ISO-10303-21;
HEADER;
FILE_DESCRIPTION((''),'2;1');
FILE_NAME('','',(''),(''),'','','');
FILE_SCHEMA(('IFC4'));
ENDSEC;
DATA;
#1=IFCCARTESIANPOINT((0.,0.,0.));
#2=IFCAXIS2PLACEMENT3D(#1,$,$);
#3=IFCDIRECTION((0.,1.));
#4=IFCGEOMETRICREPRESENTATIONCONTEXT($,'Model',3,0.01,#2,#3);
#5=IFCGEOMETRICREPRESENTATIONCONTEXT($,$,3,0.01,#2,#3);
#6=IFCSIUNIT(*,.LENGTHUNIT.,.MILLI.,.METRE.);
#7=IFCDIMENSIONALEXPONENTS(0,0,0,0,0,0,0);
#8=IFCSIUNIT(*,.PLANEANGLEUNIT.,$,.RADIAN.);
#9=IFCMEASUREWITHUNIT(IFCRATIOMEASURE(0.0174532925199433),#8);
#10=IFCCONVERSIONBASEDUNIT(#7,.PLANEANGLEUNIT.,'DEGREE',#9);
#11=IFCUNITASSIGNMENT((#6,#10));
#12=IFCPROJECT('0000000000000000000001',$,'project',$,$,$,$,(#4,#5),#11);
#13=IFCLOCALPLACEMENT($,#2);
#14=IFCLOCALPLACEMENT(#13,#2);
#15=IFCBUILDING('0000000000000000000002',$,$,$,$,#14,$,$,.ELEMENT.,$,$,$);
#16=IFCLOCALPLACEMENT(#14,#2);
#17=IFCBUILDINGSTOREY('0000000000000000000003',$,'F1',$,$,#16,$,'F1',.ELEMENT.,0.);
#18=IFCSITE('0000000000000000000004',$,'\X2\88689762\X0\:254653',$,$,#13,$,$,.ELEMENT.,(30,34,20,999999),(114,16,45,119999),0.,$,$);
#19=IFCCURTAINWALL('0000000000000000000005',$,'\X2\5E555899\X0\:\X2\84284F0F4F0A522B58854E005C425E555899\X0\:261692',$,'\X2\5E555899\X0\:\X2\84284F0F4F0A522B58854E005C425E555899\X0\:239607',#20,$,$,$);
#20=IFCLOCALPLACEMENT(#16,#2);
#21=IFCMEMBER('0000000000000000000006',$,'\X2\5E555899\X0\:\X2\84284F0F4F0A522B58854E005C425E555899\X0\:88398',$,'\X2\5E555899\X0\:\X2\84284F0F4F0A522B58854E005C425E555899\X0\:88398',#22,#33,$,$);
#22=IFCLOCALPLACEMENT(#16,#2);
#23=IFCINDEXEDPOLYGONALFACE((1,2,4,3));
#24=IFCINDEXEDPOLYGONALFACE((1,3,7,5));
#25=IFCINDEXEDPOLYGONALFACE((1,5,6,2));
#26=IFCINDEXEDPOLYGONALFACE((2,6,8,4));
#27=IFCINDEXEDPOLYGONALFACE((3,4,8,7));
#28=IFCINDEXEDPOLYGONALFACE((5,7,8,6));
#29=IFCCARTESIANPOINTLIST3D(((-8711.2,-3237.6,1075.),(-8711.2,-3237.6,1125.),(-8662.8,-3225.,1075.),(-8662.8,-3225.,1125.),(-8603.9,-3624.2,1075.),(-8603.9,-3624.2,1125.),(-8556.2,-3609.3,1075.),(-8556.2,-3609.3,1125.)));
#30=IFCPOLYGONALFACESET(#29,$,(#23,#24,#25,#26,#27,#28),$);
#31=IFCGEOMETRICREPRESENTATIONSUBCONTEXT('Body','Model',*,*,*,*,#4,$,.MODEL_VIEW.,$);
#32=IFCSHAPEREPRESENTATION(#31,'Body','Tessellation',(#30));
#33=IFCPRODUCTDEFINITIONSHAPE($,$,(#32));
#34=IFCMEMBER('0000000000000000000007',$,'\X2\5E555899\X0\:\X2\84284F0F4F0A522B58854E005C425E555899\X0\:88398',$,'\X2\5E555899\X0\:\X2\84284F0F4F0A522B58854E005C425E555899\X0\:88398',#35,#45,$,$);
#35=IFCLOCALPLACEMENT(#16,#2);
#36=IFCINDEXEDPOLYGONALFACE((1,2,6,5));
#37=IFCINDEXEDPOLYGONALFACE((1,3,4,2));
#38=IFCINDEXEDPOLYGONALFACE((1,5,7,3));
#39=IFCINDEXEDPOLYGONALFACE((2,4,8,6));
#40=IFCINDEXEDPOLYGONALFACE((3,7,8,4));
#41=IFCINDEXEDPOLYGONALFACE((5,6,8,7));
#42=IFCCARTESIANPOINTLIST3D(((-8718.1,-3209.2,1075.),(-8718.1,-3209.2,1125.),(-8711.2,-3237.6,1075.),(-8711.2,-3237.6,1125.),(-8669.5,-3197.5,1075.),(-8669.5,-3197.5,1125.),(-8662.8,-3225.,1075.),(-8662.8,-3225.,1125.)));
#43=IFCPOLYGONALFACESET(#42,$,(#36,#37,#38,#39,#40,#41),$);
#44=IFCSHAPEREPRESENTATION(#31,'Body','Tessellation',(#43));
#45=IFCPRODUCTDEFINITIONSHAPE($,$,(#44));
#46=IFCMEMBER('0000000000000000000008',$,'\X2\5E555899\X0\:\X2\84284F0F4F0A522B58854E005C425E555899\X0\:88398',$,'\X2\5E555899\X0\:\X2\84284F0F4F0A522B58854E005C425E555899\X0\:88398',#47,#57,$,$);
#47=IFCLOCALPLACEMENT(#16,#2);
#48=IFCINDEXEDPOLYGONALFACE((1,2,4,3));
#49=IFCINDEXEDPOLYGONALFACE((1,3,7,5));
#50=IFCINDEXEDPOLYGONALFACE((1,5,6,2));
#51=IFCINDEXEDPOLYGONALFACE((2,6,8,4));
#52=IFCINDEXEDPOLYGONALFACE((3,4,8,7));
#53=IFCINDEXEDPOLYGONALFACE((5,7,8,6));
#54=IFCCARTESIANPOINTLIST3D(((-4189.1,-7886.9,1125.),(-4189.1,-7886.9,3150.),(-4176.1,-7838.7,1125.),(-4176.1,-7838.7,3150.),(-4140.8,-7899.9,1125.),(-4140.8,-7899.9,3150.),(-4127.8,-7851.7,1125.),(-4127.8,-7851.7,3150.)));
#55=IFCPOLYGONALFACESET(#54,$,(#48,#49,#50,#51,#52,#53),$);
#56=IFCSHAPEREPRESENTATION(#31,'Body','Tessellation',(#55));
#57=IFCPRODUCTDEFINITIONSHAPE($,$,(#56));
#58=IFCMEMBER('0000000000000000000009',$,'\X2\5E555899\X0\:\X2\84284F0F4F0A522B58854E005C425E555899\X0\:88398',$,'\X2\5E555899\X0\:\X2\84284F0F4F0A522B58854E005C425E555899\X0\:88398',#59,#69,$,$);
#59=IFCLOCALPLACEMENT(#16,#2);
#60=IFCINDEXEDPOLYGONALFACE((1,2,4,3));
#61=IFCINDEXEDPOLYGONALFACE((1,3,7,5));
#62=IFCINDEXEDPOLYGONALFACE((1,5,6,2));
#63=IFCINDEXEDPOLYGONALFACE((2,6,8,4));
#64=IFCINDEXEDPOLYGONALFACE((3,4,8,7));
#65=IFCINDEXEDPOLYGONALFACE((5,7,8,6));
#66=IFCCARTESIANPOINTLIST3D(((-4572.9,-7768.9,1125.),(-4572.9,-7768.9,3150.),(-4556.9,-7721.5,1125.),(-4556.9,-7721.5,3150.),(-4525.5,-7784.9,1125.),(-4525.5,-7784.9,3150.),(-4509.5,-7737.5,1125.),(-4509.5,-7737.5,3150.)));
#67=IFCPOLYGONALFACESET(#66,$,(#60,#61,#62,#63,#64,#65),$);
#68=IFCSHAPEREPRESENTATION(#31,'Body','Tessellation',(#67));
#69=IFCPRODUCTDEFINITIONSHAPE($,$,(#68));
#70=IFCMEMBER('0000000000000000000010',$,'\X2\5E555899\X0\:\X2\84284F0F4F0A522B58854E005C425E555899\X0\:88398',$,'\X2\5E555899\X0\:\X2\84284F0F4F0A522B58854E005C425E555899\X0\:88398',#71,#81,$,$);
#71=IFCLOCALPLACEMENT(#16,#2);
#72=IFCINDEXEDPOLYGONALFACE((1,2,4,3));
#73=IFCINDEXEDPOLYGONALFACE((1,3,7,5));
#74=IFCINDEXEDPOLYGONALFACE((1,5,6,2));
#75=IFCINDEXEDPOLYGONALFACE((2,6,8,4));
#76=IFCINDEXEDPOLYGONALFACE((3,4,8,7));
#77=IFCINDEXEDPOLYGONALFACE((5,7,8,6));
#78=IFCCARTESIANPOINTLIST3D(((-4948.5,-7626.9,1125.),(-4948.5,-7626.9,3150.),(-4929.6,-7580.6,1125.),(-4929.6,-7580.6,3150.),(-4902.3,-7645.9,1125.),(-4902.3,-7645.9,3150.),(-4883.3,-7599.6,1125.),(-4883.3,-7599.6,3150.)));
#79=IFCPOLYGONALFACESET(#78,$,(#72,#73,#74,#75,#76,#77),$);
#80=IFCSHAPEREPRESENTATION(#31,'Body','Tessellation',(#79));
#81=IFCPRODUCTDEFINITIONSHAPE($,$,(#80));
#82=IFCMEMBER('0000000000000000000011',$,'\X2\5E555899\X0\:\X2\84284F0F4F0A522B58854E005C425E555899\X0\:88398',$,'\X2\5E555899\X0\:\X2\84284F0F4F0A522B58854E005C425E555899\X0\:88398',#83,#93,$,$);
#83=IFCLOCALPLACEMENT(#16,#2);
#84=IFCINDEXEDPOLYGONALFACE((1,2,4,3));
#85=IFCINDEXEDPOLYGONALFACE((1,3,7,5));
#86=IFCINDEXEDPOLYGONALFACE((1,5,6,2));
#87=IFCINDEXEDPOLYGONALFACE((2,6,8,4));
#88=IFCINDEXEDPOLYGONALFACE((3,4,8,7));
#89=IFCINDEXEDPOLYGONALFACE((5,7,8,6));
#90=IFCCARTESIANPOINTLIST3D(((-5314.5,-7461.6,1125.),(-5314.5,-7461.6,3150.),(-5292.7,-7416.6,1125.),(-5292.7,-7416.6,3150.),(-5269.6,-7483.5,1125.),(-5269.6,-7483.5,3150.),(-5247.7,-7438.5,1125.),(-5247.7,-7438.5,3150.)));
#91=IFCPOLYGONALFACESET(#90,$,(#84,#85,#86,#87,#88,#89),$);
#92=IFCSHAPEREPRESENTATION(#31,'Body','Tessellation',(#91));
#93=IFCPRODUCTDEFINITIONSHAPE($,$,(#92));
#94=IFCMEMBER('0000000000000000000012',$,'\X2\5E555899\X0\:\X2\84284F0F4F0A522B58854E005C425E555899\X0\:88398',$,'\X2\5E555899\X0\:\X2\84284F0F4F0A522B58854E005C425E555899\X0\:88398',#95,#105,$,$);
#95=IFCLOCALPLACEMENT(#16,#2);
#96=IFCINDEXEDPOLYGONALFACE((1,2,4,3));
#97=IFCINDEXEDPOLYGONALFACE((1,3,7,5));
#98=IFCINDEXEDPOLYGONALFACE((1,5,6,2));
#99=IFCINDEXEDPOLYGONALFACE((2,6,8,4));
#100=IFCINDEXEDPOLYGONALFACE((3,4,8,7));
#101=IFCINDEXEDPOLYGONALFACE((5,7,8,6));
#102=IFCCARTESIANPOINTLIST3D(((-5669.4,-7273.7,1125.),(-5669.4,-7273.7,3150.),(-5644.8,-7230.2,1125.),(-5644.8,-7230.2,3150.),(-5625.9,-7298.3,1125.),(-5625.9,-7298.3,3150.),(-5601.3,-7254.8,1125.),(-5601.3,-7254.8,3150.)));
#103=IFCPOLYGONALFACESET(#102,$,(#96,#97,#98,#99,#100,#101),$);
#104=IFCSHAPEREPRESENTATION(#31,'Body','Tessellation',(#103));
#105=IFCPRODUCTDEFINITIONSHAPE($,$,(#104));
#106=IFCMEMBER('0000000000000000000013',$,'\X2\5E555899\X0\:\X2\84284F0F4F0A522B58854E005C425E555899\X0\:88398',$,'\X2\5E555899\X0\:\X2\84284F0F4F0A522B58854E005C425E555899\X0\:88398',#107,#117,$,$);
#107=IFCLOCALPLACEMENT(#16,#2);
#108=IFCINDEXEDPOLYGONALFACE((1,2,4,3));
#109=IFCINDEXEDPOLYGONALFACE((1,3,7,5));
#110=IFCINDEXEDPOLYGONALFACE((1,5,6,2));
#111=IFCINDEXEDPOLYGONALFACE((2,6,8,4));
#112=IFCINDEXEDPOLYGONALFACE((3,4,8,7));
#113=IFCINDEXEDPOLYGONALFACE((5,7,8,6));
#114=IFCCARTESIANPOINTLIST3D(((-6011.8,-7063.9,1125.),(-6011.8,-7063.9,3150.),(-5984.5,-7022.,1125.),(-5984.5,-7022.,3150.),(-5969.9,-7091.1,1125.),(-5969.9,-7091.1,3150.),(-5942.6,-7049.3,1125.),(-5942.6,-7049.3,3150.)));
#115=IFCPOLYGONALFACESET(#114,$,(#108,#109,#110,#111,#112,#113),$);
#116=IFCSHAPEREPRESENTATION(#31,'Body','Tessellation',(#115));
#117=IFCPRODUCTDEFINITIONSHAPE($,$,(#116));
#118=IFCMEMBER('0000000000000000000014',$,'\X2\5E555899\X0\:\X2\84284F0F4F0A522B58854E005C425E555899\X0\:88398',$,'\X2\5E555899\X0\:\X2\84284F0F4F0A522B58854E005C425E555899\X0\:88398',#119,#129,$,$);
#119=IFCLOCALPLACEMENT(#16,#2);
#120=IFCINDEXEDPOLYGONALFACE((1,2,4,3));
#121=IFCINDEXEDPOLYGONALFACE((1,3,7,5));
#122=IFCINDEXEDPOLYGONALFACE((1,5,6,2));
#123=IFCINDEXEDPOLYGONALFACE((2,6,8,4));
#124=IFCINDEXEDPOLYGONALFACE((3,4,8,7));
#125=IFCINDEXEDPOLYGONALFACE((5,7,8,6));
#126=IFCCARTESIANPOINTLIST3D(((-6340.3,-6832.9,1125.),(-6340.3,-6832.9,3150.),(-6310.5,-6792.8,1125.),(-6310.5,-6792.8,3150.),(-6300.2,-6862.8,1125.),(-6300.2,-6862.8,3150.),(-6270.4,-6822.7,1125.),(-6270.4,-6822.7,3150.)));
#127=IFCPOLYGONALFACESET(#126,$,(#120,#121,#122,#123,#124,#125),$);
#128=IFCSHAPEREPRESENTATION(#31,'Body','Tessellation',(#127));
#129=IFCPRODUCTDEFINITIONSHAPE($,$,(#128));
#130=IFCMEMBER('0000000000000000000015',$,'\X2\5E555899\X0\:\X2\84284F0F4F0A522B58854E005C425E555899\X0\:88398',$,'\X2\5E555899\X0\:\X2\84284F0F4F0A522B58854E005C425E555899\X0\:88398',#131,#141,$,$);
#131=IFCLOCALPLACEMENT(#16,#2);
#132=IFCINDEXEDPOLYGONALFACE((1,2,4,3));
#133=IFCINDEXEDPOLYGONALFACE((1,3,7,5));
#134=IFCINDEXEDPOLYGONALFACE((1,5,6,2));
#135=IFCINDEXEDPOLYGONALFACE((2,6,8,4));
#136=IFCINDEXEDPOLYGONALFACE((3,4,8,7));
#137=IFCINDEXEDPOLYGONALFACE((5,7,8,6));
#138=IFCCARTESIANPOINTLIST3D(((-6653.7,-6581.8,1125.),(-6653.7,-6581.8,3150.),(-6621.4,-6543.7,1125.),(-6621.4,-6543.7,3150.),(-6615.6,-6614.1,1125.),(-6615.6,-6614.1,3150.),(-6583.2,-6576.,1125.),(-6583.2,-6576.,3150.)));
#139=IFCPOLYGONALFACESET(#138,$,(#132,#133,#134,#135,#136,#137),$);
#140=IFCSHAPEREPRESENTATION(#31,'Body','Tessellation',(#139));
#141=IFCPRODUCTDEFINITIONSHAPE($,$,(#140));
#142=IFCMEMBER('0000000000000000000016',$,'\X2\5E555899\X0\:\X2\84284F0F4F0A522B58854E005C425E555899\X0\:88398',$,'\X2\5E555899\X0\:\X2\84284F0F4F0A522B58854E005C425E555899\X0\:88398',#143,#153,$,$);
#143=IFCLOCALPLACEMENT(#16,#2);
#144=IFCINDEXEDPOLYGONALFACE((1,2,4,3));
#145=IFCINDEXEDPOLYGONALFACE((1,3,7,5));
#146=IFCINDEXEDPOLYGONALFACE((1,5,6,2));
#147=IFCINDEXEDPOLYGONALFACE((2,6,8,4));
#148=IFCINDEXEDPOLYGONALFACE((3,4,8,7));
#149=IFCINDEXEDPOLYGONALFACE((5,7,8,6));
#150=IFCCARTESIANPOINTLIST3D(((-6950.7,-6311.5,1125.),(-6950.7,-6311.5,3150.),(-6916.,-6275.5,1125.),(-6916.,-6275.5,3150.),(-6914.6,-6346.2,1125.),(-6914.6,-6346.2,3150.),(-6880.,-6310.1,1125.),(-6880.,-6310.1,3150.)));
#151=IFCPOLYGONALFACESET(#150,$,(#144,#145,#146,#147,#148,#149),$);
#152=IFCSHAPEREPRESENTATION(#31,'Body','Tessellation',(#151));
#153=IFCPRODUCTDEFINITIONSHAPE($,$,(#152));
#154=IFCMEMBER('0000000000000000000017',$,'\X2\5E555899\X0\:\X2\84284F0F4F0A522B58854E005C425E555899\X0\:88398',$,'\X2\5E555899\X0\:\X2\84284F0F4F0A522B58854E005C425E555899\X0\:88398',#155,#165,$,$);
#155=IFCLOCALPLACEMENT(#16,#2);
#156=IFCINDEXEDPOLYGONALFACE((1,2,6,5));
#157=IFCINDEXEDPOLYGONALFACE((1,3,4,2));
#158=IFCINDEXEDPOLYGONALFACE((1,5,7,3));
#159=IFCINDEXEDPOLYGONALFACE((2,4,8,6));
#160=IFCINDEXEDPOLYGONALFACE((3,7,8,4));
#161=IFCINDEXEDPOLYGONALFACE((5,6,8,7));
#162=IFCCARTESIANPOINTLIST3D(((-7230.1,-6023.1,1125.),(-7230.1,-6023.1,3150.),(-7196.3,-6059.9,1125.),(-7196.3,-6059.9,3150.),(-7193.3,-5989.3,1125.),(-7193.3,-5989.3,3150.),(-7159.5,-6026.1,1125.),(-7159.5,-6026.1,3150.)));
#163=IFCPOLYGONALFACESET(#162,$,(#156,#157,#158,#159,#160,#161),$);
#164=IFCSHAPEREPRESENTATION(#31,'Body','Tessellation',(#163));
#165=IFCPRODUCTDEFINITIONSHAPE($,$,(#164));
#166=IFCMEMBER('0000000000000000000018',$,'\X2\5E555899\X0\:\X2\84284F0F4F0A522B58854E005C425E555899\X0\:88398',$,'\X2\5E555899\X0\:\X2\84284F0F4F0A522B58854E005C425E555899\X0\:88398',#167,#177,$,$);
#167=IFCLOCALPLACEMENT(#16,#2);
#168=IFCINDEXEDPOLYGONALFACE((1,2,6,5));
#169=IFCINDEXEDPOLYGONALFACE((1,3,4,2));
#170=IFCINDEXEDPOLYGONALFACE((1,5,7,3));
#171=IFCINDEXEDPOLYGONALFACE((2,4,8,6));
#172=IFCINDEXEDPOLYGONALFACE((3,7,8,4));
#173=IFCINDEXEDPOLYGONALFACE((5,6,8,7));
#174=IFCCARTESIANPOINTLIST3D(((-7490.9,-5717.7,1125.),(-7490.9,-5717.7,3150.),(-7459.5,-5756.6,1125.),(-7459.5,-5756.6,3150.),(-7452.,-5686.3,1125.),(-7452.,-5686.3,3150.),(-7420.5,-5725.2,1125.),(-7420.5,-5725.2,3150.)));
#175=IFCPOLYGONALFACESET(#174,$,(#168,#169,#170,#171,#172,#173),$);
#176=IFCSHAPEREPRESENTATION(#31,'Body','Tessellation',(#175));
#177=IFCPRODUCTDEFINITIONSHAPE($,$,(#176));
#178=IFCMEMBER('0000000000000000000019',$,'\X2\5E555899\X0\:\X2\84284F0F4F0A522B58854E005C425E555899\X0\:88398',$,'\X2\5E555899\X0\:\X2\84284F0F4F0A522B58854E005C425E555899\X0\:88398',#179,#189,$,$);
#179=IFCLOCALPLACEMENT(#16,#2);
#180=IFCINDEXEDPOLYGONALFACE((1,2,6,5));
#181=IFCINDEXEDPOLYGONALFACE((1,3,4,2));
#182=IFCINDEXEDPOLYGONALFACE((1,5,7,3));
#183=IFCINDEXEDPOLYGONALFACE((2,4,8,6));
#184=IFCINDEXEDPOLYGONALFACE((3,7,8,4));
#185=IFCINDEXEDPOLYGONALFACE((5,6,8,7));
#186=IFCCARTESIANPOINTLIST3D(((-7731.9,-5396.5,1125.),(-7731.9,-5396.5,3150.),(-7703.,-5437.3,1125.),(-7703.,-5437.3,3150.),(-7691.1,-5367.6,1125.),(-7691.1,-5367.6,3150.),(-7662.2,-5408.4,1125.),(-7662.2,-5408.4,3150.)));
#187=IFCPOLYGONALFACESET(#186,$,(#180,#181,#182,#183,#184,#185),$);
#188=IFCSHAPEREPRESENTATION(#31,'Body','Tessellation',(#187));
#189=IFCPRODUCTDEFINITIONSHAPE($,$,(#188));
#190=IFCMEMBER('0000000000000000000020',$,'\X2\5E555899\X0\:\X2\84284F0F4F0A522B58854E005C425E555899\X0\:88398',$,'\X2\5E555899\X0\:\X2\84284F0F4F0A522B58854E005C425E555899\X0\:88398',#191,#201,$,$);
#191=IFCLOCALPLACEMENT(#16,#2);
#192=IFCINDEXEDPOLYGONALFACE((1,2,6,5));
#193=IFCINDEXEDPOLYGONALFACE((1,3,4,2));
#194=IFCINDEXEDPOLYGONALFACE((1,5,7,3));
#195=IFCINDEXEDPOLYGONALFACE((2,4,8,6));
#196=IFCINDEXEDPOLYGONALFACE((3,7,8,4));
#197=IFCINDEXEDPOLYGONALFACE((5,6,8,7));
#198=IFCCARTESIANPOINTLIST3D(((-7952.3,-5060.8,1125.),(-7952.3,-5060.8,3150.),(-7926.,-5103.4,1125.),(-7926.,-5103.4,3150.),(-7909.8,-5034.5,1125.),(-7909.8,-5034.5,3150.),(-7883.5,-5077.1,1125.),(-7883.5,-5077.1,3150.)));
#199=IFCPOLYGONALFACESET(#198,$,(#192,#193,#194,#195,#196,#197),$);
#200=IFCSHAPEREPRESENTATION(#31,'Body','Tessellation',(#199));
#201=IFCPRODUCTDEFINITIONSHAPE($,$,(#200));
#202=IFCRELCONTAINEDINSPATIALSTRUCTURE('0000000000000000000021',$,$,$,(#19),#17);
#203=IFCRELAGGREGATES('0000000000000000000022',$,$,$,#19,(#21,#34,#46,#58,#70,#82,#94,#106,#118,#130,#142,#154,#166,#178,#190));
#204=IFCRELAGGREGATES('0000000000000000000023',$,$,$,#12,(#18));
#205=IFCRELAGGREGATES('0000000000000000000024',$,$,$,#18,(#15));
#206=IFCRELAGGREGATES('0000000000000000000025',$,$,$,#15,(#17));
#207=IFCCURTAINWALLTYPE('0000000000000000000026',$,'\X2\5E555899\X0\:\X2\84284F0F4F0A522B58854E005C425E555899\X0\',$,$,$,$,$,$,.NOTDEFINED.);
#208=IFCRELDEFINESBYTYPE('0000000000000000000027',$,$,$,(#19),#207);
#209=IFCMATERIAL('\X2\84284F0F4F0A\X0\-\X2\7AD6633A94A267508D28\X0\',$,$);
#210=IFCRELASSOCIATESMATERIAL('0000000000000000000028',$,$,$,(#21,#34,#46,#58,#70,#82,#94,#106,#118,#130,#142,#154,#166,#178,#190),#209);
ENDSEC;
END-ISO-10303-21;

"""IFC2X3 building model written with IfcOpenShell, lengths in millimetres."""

from ifc_helpers import new_model, entity, si_unit, converted_unit, direction, frame, frame_2d, origin, origin_2d_with_axis, place, context, subcontext, project, spatial, rectangle, extrude, clip, halfspace, material, type_object, element, aggregate, save


model = new_model("IFC2X3")

# Units and contexts
model_context = context("Model", 3, precision=0.01, world=origin(), true_north=direction((0.0, 1.0)))
context_of_model = context(None, 3, precision=0.01, world=origin(), true_north=direction((0.0, 1.0)))
body_context = subcontext(model_context, "Body", "Model", "MODEL_VIEW")
ifc_project = project(units=[si_unit("LENGTHUNIT", "METRE", prefix="MILLI"), converted_unit("PLANEANGLEUNIT", "DEGREE", entity("IfcRatioMeasure", 0.0174532925199433), si_unit("PLANEANGLEUNIT", "RADIAN"), dimensions=[0, 0, 0, 0, 0, 0, 0])], contexts=[model_context, context_of_model])

# Site, building, storey
site_placement = place(None, origin())
site = spatial("IfcSite", under=ifc_project, at=site_placement, Name="表面:254653", CompositionType="ELEMENT", RefLatitude=(30, 34, 20, 999999), RefLongitude=(114, 16, 45, 119999), RefElevation=0.0)
building_placement = place(site_placement, origin())
building = spatial("IfcBuilding", under=site, at=building_placement, CompositionType="ELEMENT")
storey_placement = place(building_placement, origin())
storey = spatial("IfcBuildingStorey", under=building, at=storey_placement, Name="F1", LongName="F1", CompositionType="ELEMENT", Elevation=0.0)

# Curtain wall, members
curtain_wall_type_1 = type_object("IfcCurtainWallType", Name="幕墙:萨伏伊别墅一层幕墙", PredefinedType="NOTDEFINED")
curtain_wall_1_placement = place(storey_placement, origin())
curtain_wall_1 = element("IfcCurtainWall", 1, at=curtain_wall_1_placement, inside=storey, type_object=curtain_wall_type_1, Name="幕墙:萨伏伊别墅一层幕墙:261692", ObjectType="幕墙:萨伏伊别墅一层幕墙:239607")
ifc_material_1 = material(Name="萨伏伊-竖挺钢材质")
member_1_placement = place(curtain_wall_1_placement, origin())
member_1 = element("IfcMember", 2, at=member_1_placement, material=ifc_material_1, Name="幕墙:萨伏伊别墅一层幕墙:88398", ObjectType="幕墙:萨伏伊别墅一层幕墙:88398", context=body_context, shape_type="Clipping", body=[
    clip(clip(extrude(rectangle(XDim=50.0, YDim=50.0, at=frame_2d((0.0, 0.0), x_axis=(1.0, 0.0))), frame((-8687.1, -3230.9, 1100.0), z_axis=(0.267379, -0.963592, 0.0), x_axis=(0.0, 0.0, -1.0)), (0.0, 0.0, 1.0), 401.2), halfspace(frame((-8687.0, -3231.3, 795.2), z_axis=(-0.251115, 0.967957, 0.0), x_axis=(0.967957, 0.251115, 0.0)), False)), halfspace(frame((-8580.1, -3616.7, 795.2), z_axis=(0.297522, -0.954715, 0.0), x_axis=(0.954715, 0.297522, 0.0)), False)),
])
member_2_placement = place(curtain_wall_1_placement, origin())
member_2 = element("IfcMember", 3, at=member_2_placement, material=ifc_material_1, Name="幕墙:萨伏伊别墅一层幕墙:88398", ObjectType="幕墙:萨伏伊别墅一层幕墙:88398", context=body_context, shape_type="Clipping", body=[
    clip(extrude(rectangle(XDim=50.0, YDim=50.0, at=frame_2d((0.0, 0.0), x_axis=(1.0, 0.0))), frame((-8693.8, -3203.4, 1100.0), z_axis=(0.234779, -0.972049, 0.0), x_axis=(0.0, 0.0, -1.0)), (0.0, 0.0, 1.0), 29.1), halfspace(frame((-8687.0, -3231.3, 795.2), z_axis=(0.251115, -0.967957, 0.0), x_axis=(0.967957, 0.251115, 0.0)), False)),
])
member_3_placement = place(curtain_wall_1_placement, origin())
member_3 = element("IfcMember", 4, at=member_3_placement, material=ifc_material_1, Name="幕墙:萨伏伊别墅一层幕墙:88398", ObjectType="幕墙:萨伏伊别墅一层幕墙:88398", context=body_context, shape_type="SweptSolid", body=[
    extrude(rectangle(XDim=50.0, YDim=50.0, at=frame_2d((0.0, 0.0), x_axis=(1.0, 0.0))), frame((-4158.4, -7869.3, 1125.0), z_axis=(0.0, 0.0, 1.0), x_axis=(0.2601, 0.965582, 0.0)), (0.0, 0.0, 1.0), 2025.0),
])
member_4_placement = place(curtain_wall_1_placement, origin())
member_4 = element("IfcMember", 5, at=member_4_placement, material=ifc_material_1, Name="幕墙:萨伏伊别墅一层幕墙:88398", ObjectType="幕墙:萨伏伊别墅一层幕墙:88398", context=body_context, shape_type="SweptSolid", body=[
    extrude(rectangle(XDim=50.0, YDim=50.0, at=origin_2d_with_axis()), frame((-4541.2, -7753.2, 1125.0), z_axis=(0.0, 0.0, 1.0), x_axis=(0.320231, 0.947339, 0.0)), (0.0, 0.0, 1.0), 2025.0),
])
member_5_placement = place(curtain_wall_1_placement, origin())
member_5 = element("IfcMember", 6, at=member_5_placement, material=ifc_material_1, Name="幕墙:萨伏伊别墅一层幕墙:88398", ObjectType="幕墙:萨伏伊别墅一层幕墙:88398", context=body_context, shape_type="SweptSolid", body=[
    extrude(rectangle(XDim=50.0, YDim=50.0, at=frame_2d((0.0, 0.0), x_axis=(1.0, 0.0))), frame((-4915.9, -7613.2, 1125.0), z_axis=(0.0, 0.0, 1.0), x_axis=(0.379099, 0.925356, 0.0)), (0.0, 0.0, 1.0), 2025.0),
])
member_6_placement = place(curtain_wall_1_placement, origin())
member_6 = element("IfcMember", 7, at=member_6_placement, material=ifc_material_1, Name="幕墙:萨伏伊别墅一层幕墙:88398", ObjectType="幕墙:萨伏伊别墅一层幕墙:88398", context=body_context, shape_type="SweptSolid", body=[
    extrude(rectangle(XDim=50.0, YDim=50.0, at=frame_2d((0.0, 0.0), x_axis=(1.0, 0.0))), frame((-5281.1, -7450.1, 1125.0), z_axis=(0.0, 0.0, 1.0), x_axis=(0.436469, 0.899719, 0.0)), (0.0, 0.0, 1.0), 2025.0),
])
member_7_placement = place(curtain_wall_1_placement, origin())
member_7 = element("IfcMember", 8, at=member_7_placement, material=ifc_material_1, Name="幕墙:萨伏伊别墅一层幕墙:88398", ObjectType="幕墙:萨伏伊别墅一层幕墙:88398", context=body_context, shape_type="SweptSolid", body=[
    extrude(rectangle(XDim=50.0, YDim=50.0, at=origin_2d_with_axis()), frame((-5635.4, -7264.2, 1125.0), z_axis=(0.0, 0.0, 1.0), x_axis=(0.492116, 0.870529, 0.0)), (0.0, 0.0, 1.0), 2025.0),
])
member_8_placement = place(curtain_wall_1_placement, origin())
member_8 = element("IfcMember", 9, at=member_8_placement, material=ifc_material_1, Name="幕墙:萨伏伊别墅一层幕墙:88398", ObjectType="幕墙:萨伏伊别墅一层幕墙:88398", context=body_context, shape_type="SweptSolid", body=[
    extrude(rectangle(XDim=50.0, YDim=50.0, at=frame_2d((0.0, 0.0), x_axis=(1.0, 0.0))), frame((-5977.2, -7056.6, 1125.0), z_axis=(0.0, 0.0, 1.0), x_axis=(0.54582, 0.837902, 0.0)), (0.0, 0.0, 1.0), 2025.0),
])
member_9_placement = place(curtain_wall_1_placement, origin())
member_9 = element("IfcMember", 10, at=member_9_placement, material=ifc_material_1, Name="幕墙:萨伏伊别墅一层幕墙:88398", ObjectType="幕墙:萨伏伊别墅一层幕墙:88398", context=body_context, shape_type="SweptSolid", body=[
    extrude(rectangle(XDim=50.0, YDim=50.0, at=origin_2d_with_axis()), frame((-6305.3, -6827.8, 1125.0), z_axis=(0.0, 0.0, 1.0), x_axis=(0.597369, 0.801967, 0.0)), (0.0, 0.0, 1.0), 2025.0),
])
member_10_placement = place(curtain_wall_1_placement, origin())
member_10 = element("IfcMember", 11, at=member_10_placement, material=ifc_material_1, Name="幕墙:萨伏伊别墅一层幕墙:88398", ObjectType="幕墙:萨伏伊别墅一层幕墙:88398", context=body_context, shape_type="SweptSolid", body=[
    extrude(rectangle(XDim=50.0, YDim=50.0, at=frame_2d((0.0, 0.0), x_axis=(1.0, 0.0))), frame((-6618.5, -6578.9, 1125.0), z_axis=(0.0, 0.0, 1.0), x_axis=(0.646558, 0.762864, 0.0)), (0.0, 0.0, 1.0), 2025.0),
])
member_11_placement = place(curtain_wall_1_placement, origin())
member_11 = element("IfcMember", 12, at=member_11_placement, material=ifc_material_1, Name="幕墙:萨伏伊别墅一层幕墙:88398", ObjectType="幕墙:萨伏伊别墅一层幕墙:88398", context=body_context, shape_type="SweptSolid", body=[
    extrude(rectangle(XDim=50.0, YDim=50.0, at=frame_2d((0.0, 0.0), x_axis=(1.0, 0.0))), frame((-6915.3, -6310.8, 1125.0), z_axis=(0.0, 0.0, 1.0), x_axis=(0.693195, 0.72075, 0.0)), (0.0, 0.0, 1.0), 2025.0),
])
member_12_placement = place(curtain_wall_1_placement, origin())
member_12 = element("IfcMember", 13, at=member_12_placement, material=ifc_material_1, Name="幕墙:萨伏伊别墅一层幕墙:88398", ObjectType="幕墙:萨伏伊别墅一层幕墙:88398", context=body_context, shape_type="SweptSolid", body=[
    extrude(rectangle(XDim=50.0, YDim=50.0, at=frame_2d((0.0, 0.0), x_axis=(1.0, 0.0))), frame((-7194.8, -6024.6, 1125.0), z_axis=(0.0, 0.0, 1.0), x_axis=(0.737095, 0.675789, 0.0)), (0.0, 0.0, 1.0), 2025.0),
])
member_13_placement = place(curtain_wall_1_placement, origin())
member_13 = element("IfcMember", 14, at=member_13_placement, material=ifc_material_1, Name="幕墙:萨伏伊别墅一层幕墙:88398", ObjectType="幕墙:萨伏伊别墅一层幕墙:88398", context=body_context, shape_type="SweptSolid", body=[
    extrude(rectangle(XDim=50.0, YDim=50.0, at=origin_2d_with_axis()), frame((-7455.7, -5721.4, 1125.0), z_axis=(0.0, 0.0, 1.0), x_axis=(0.778084, 0.62816, 0.0)), (0.0, 0.0, 1.0), 2025.0),
])
member_14_placement = place(curtain_wall_1_placement, origin())
member_14 = element("IfcMember", 15, at=member_14_placement, material=ifc_material_1, Name="幕墙:萨伏伊别墅一层幕墙:88398", ObjectType="幕墙:萨伏伊别墅一层幕墙:88398", context=body_context, shape_type="SweptSolid", body=[
    extrude(rectangle(XDim=50.0, YDim=50.0, at=frame_2d((0.0, 0.0), x_axis=(1.0, 0.0))), frame((-7697.1, -5402.5, 1125.0), z_axis=(0.0, 0.0, 1.0), x_axis=(0.816001, 0.578051, 0.0)), (0.0, 0.0, 1.0), 2025.0),
])
member_15_placement = place(curtain_wall_1_placement, origin())
member_15 = element("IfcMember", 16, at=member_15_placement, material=ifc_material_1, Name="幕墙:萨伏伊别墅一层幕墙:88398", ObjectType="幕墙:萨伏伊别墅一层幕墙:88398", context=body_context, shape_type="SweptSolid", body=[
    extrude(rectangle(XDim=50.0, YDim=50.0, at=frame_2d((0.0, 0.0), x_axis=(1.0, 0.0))), frame((-7917.9, -5068.9, 1125.0), z_axis=(0.0, 0.0, 1.0), x_axis=(-0.525659, 0.850695, 0.0)), (0.0, 0.0, 1.0), 2025.0),
])
aggregate(curtain_wall_1, [member_1, member_2, member_3, member_4, member_5, member_6, member_7, member_8, member_9, member_10, member_11, member_12, member_13, member_14, member_15])

save(model, "model.ifc")
